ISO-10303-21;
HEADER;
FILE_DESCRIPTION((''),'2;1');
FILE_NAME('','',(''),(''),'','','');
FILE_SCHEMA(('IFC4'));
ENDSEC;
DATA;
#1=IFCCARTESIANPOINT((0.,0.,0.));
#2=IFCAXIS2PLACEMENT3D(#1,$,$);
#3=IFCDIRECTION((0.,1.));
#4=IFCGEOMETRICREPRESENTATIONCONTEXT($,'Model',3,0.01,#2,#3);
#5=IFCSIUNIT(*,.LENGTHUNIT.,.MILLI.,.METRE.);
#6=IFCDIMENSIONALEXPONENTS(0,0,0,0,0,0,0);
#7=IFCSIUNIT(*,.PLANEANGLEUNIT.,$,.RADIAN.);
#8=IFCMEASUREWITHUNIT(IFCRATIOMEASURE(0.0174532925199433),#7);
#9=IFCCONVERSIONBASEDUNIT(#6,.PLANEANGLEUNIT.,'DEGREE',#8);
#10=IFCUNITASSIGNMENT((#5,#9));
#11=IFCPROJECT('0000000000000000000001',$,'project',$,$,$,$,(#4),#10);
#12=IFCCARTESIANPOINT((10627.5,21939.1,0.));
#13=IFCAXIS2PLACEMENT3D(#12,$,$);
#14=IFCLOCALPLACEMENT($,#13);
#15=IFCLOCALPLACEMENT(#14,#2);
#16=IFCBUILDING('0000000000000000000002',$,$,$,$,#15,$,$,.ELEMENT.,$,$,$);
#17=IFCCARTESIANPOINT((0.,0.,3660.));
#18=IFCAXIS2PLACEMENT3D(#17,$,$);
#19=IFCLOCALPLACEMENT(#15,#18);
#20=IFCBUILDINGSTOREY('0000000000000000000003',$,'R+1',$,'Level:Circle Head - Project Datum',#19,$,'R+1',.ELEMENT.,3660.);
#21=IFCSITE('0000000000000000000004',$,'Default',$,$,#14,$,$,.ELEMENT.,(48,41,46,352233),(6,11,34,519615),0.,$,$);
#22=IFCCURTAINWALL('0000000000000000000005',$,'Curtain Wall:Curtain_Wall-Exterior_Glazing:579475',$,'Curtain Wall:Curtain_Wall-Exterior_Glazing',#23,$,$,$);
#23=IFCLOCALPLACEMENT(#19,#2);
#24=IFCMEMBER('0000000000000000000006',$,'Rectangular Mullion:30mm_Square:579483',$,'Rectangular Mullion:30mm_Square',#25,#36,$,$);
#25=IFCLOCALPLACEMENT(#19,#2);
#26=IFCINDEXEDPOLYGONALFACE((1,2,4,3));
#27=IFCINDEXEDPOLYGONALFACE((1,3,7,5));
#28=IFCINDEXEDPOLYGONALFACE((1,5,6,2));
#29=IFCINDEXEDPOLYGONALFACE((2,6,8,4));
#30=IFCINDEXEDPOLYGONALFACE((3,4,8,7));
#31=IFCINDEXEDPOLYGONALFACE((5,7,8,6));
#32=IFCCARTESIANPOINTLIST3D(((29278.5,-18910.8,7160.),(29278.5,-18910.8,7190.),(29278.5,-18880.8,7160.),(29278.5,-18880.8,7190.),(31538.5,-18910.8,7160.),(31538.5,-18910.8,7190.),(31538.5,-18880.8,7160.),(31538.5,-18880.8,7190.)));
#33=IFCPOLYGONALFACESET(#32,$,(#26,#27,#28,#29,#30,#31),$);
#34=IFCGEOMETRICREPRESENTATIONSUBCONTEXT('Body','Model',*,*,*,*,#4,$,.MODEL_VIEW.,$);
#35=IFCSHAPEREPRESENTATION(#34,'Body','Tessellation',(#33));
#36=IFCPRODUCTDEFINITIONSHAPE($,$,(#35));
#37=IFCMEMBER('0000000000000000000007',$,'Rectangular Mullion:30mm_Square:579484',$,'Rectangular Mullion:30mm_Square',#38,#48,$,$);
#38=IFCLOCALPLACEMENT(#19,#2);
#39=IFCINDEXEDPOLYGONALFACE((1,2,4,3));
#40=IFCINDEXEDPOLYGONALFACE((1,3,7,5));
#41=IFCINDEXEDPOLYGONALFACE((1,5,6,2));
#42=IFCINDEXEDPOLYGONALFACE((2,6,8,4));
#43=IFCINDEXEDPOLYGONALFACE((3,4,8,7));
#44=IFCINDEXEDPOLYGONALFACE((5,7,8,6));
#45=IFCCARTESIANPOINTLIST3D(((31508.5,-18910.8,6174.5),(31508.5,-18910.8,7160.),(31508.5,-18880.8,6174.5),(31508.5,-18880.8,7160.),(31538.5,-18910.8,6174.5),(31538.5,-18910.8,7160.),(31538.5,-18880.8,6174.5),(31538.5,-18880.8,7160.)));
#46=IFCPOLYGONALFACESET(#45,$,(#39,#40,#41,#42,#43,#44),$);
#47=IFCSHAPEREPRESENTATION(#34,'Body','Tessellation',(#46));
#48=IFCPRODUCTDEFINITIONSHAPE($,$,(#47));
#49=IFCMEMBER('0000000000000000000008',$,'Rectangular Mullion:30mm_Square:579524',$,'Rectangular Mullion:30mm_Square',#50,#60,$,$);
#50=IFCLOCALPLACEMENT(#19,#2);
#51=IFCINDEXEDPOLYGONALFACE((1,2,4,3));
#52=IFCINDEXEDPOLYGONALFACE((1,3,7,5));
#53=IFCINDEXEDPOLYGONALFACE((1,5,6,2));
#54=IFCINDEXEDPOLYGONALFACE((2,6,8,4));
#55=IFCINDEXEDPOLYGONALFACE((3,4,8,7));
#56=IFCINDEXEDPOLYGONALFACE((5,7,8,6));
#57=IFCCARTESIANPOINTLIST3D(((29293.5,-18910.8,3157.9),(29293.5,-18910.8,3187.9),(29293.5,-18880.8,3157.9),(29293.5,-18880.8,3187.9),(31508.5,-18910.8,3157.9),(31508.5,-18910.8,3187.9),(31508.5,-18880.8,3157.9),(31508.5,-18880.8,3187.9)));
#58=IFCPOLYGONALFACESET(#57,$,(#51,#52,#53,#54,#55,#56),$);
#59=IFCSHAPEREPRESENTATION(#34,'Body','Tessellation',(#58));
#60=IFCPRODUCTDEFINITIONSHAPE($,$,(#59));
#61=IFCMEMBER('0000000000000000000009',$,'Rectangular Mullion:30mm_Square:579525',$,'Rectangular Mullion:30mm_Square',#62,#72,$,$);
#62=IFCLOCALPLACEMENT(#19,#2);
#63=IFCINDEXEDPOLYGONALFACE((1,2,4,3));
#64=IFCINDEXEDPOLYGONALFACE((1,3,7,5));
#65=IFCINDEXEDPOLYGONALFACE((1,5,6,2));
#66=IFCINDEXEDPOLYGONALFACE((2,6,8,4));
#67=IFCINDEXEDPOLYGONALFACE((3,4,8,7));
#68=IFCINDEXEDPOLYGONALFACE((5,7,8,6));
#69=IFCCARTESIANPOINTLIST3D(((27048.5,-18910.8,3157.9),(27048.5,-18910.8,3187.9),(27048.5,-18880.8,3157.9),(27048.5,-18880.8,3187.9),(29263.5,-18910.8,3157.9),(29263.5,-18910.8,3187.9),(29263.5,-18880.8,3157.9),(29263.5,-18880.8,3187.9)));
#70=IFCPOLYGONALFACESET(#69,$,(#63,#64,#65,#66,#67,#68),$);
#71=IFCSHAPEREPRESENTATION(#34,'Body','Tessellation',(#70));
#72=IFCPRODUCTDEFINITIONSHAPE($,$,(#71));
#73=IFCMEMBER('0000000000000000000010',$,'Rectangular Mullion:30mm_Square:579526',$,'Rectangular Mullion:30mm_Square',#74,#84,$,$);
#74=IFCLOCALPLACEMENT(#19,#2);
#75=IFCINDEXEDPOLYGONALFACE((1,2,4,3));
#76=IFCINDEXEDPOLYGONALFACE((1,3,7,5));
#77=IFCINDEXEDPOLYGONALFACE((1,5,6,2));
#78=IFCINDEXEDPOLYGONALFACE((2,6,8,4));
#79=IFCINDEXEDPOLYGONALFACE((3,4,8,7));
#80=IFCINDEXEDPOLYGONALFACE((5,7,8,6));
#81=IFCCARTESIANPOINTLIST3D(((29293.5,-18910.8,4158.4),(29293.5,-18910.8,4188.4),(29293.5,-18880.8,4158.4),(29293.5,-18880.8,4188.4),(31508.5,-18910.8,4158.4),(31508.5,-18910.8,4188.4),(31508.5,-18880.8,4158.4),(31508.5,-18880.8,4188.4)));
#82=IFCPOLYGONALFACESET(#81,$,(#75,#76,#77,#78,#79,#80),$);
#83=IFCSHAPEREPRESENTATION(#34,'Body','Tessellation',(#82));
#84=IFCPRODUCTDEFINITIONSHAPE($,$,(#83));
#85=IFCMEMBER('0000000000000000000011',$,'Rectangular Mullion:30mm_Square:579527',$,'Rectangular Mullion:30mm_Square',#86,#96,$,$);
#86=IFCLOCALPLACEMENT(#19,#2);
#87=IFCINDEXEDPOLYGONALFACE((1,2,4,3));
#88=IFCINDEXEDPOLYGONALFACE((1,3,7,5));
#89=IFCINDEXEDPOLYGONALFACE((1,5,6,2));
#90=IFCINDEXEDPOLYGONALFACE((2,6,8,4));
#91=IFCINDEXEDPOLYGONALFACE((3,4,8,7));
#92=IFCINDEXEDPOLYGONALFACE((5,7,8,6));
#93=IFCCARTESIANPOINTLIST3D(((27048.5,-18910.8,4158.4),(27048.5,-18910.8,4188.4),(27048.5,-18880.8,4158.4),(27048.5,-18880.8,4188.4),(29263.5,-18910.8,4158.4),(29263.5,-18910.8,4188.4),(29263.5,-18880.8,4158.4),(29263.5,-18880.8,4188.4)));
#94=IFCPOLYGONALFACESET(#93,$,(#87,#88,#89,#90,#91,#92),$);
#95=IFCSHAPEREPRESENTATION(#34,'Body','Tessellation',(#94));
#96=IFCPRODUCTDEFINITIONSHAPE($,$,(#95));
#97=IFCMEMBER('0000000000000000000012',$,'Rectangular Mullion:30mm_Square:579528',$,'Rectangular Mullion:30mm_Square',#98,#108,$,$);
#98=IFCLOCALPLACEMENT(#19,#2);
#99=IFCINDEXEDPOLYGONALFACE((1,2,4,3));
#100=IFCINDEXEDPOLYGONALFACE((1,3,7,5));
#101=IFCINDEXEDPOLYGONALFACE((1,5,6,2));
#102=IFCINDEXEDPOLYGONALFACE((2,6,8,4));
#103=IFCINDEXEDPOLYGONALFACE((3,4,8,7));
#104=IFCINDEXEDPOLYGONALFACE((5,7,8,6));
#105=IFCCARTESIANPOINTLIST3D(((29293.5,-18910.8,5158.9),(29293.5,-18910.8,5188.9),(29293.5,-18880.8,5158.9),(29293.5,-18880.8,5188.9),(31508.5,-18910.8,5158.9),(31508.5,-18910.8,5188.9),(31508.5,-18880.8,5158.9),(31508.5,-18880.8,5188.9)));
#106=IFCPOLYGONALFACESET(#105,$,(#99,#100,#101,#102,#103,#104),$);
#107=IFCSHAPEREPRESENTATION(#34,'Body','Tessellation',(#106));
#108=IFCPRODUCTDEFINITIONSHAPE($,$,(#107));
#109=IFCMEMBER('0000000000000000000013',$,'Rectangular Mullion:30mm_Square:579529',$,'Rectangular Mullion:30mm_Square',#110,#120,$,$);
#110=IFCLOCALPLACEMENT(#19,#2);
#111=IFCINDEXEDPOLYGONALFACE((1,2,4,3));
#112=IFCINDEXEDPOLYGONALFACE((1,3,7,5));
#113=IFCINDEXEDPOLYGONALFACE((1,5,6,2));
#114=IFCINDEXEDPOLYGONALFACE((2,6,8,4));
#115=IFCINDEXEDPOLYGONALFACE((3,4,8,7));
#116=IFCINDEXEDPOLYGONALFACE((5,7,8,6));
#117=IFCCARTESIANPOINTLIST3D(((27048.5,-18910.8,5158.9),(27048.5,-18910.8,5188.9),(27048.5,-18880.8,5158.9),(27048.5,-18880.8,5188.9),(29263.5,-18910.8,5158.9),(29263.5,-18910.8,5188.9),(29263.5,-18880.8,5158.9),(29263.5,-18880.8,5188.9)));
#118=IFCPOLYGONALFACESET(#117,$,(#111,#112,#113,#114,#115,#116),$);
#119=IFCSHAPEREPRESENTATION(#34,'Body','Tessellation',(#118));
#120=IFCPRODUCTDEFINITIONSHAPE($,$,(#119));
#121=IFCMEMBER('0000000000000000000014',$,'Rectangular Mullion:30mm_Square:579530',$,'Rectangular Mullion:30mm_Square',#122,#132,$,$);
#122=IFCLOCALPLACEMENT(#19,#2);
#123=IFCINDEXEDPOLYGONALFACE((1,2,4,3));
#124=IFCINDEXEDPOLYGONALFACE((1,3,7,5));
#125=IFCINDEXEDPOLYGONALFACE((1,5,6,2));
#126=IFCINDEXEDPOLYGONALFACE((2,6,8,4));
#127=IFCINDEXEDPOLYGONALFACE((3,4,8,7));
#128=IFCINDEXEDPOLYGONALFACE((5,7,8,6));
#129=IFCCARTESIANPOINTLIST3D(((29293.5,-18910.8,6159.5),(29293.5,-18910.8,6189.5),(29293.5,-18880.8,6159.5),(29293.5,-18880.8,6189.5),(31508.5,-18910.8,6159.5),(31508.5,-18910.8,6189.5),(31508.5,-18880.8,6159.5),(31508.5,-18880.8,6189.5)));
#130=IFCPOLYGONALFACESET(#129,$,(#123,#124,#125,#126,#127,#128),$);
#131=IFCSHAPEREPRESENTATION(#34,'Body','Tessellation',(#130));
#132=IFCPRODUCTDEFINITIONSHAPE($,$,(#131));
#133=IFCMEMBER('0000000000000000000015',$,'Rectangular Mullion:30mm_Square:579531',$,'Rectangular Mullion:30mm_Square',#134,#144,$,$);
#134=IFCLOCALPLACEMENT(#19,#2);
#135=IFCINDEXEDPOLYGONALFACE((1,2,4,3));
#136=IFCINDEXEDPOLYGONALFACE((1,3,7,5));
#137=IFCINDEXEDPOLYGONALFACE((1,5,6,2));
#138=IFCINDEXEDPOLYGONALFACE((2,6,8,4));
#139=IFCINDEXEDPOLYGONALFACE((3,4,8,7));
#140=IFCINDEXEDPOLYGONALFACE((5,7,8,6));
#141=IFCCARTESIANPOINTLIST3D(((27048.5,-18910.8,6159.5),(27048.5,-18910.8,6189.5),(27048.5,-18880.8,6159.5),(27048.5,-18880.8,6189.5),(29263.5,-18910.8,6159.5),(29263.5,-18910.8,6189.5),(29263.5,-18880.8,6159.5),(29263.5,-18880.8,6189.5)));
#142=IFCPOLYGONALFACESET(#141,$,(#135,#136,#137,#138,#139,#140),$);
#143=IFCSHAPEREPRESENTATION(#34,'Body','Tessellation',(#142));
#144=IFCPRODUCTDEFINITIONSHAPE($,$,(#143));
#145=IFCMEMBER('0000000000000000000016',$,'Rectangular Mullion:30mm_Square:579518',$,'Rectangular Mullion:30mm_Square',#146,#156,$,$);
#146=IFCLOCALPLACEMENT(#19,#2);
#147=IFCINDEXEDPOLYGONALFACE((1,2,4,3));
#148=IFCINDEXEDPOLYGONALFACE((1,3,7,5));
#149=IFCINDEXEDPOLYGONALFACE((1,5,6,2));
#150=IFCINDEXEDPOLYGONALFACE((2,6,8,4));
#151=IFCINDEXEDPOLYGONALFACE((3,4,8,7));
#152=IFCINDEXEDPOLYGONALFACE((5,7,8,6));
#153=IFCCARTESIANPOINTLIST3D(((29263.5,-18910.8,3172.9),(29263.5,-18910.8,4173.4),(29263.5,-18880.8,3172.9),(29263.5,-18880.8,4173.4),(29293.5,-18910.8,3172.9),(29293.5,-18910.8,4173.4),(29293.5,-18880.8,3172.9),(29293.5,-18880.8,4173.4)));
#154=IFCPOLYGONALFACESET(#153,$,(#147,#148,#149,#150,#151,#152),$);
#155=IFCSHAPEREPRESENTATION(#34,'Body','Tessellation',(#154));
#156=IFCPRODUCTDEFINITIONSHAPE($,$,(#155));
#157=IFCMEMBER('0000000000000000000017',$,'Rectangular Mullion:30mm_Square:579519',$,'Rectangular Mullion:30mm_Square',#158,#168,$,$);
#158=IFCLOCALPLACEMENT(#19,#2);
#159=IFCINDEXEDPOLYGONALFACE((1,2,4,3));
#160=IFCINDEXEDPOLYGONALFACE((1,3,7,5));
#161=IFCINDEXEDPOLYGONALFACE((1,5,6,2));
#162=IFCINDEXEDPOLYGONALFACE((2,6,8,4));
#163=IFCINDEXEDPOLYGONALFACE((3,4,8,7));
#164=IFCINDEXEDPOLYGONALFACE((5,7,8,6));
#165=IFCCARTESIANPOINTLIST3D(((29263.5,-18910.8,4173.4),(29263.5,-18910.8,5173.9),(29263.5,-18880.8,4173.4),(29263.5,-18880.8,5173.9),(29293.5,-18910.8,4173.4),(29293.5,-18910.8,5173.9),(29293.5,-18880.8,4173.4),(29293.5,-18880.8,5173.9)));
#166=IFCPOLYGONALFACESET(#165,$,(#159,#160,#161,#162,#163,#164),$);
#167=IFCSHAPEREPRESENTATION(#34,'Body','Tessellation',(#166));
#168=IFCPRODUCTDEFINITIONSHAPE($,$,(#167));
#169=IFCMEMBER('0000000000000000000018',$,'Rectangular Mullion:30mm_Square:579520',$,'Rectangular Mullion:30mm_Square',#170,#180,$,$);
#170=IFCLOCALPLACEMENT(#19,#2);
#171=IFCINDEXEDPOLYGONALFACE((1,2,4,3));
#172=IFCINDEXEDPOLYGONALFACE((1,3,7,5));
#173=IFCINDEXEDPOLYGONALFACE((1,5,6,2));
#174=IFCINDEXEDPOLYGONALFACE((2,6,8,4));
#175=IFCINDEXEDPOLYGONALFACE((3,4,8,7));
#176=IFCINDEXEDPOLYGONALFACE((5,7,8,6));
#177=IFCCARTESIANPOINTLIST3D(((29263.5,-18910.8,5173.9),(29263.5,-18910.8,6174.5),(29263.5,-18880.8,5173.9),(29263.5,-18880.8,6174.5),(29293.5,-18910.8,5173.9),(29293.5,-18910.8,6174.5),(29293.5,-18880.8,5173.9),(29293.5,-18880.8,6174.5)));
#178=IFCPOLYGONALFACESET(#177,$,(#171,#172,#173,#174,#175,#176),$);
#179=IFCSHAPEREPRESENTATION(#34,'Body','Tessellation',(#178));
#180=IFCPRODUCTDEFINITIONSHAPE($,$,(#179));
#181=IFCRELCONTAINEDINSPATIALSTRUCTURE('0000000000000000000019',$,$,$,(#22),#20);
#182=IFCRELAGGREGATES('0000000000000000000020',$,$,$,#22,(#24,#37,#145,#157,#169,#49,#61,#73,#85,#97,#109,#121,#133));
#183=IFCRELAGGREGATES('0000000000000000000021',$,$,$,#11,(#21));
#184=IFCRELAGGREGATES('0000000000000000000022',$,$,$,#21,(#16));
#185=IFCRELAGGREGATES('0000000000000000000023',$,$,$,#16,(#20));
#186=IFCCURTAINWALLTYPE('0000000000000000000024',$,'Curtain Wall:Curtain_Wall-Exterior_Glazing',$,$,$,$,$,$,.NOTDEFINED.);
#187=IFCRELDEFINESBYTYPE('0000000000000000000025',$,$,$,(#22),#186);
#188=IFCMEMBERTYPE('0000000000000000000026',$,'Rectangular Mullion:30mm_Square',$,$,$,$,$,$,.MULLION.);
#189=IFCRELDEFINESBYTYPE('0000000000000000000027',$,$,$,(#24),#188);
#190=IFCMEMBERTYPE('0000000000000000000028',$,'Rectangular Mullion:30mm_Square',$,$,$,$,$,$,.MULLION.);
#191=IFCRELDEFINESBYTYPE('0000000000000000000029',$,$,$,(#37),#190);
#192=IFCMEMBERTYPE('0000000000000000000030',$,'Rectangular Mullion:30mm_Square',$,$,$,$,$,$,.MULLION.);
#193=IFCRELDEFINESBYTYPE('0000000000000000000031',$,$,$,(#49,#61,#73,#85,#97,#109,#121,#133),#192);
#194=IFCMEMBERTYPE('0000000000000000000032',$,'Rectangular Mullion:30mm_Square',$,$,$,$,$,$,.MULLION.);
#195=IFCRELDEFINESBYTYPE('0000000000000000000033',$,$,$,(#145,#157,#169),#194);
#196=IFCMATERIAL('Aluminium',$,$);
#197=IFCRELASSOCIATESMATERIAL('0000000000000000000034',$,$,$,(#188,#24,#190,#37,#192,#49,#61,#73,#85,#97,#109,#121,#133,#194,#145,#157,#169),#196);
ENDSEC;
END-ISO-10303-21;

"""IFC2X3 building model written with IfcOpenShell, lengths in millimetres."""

from ifc_helpers import new_model, entity, si_unit, converted_unit, direction, frame, origin, origin_2d_with_axis, place, context, subcontext, project, spatial, rectangle, extrude, source, transform, mapped, material, type_object, type_shapes, element, aggregate, save


model = new_model("IFC2X3")

# Units and contexts
model_context = context("Model", 3, precision=0.01, world=origin(), true_north=direction((0.0, 1.0)))
body_context = subcontext(model_context, "Body", "Model", "MODEL_VIEW")
ifc_project = project(units=[si_unit("LENGTHUNIT", "METRE", prefix="MILLI"), converted_unit("PLANEANGLEUNIT", "DEGREE", entity("IfcRatioMeasure", 0.0174532925199433), si_unit("PLANEANGLEUNIT", "RADIAN"), dimensions=[0, 0, 0, 0, 0, 0, 0])], contexts=[model_context])

# Site, building, storey
site_placement = place(None, frame((10627.5, 21939.1, 0.0)))
site = spatial("IfcSite", under=ifc_project, at=site_placement, Name="Default", CompositionType="ELEMENT", RefLatitude=(48, 41, 46, 352233), RefLongitude=(6, 11, 34, 519615), RefElevation=0.0)
building_placement = place(site_placement, origin())
building = spatial("IfcBuilding", under=site, at=building_placement, CompositionType="ELEMENT")
storey_placement = place(building_placement, frame((0.0, 0.0, 3660.0)))
storey = spatial("IfcBuildingStorey", under=building, at=storey_placement, Name="R+1", ObjectType="Level:Circle Head - Project Datum", LongName="R+1", CompositionType="ELEMENT", Elevation=3660.0)

# Curtain wall, members
curtain_wall_type = type_object("IfcCurtainWallType", Name="Curtain Wall:Curtain_Wall-Exterior_Glazing", PredefinedType="NOTDEFINED")
curtain_wall_placement = place(storey_placement, frame((0.0, 0.0, -3660.0)))
curtain_wall = element("IfcCurtainWall", 1, at=curtain_wall_placement, inside=storey, type_object=curtain_wall_type, Name="Curtain Wall:Curtain_Wall-Exterior_Glazing:579475", ObjectType="Curtain Wall:Curtain_Wall-Exterior_Glazing")
ifc_material_1 = material(Name="Aluminium")
member_type_1 = type_object("IfcMemberType", Name="Rectangular Mullion:30mm_Square", PredefinedType="MULLION", material=ifc_material_1)
shared_shape_1 = source(origin(), body_context, "Body", "SweptSolid", [
    extrude(rectangle(XDim=30.0, YDim=30.0, at=origin_2d_with_axis()), frame((-15.0, 0.0, -2260.0), z_axis=(0.0, 0.0, 1.0), x_axis=(0.0, -1.0, 0.0)), (0.0, 0.0, 1.0), 2260.0),
])
type_shapes(member_type_1, [shared_shape_1])
member_1_placement = place(storey_placement, frame((29278.5, -18895.8, 7190.0), z_axis=(-1.0, 0.0, 0.0), x_axis=(0.0, 0.0, 1.0)))
member_1 = element("IfcMember", 2, at=member_1_placement, type_object=member_type_1, material=ifc_material_1, Name="Rectangular Mullion:30mm_Square:579483", ObjectType="Rectangular Mullion:30mm_Square", context=body_context, shape_type="MappedRepresentation", body=[
    mapped(shared_shape_1, transform((0.0, 0.0, 0.0), scale=1.0)),
])
member_type_2 = type_object("IfcMemberType", Name="Rectangular Mullion:30mm_Square", PredefinedType="MULLION", material=ifc_material_1)
shared_shape_2 = source(origin(), body_context, "Body", "SweptSolid", [
    extrude(rectangle(XDim=30.0, YDim=30.0, at=origin_2d_with_axis()), frame((-15.0, 0.0, -985.5), z_axis=(0.0, 0.0, 1.0), x_axis=(0.0, -1.0, 0.0)), (0.0, 0.0, 1.0), 985.5),
])
type_shapes(member_type_2, [shared_shape_2])
member_2_placement = place(storey_placement, frame((31538.5, -18895.8, 7160.0)))
member_2 = element("IfcMember", 3, at=member_2_placement, type_object=member_type_2, material=ifc_material_1, Name="Rectangular Mullion:30mm_Square:579484", ObjectType="Rectangular Mullion:30mm_Square", context=body_context, shape_type="MappedRepresentation", body=[
    mapped(shared_shape_2, transform((0.0, 0.0, 0.0), scale=1.0)),
])
member_type_3 = type_object("IfcMemberType", Name="Rectangular Mullion:30mm_Square", PredefinedType="MULLION", material=ifc_material_1)
shared_shape_3 = source(origin(), body_context, "Body", "SweptSolid", [
    extrude(rectangle(XDim=30.0, YDim=30.0, at=origin_2d_with_axis()), frame((0.0, 0.0, -2215.0), z_axis=(0.0, 0.0, 1.0), x_axis=(0.0, -1.0, 0.0)), (0.0, 0.0, 1.0), 2215.0),
])
type_shapes(member_type_3, [shared_shape_3])
member_3_placement = place(storey_placement, frame((29293.5, -18895.8, 3172.9), z_axis=(-1.0, 0.0, 0.0), x_axis=(0.0, 0.0, 1.0)))
member_3 = element("IfcMember", 4, at=member_3_placement, type_object=member_type_3, material=ifc_material_1, Name="Rectangular Mullion:30mm_Square:579524", ObjectType="Rectangular Mullion:30mm_Square", context=body_context, shape_type="MappedRepresentation", body=[
    mapped(shared_shape_3, transform((0.0, 0.0, 0.0), scale=1.0)),
])
member_4_placement = place(storey_placement, frame((27048.5, -18895.8, 3172.9), z_axis=(-1.0, 0.0, 0.0), x_axis=(0.0, 0.0, 1.0)))
member_4 = element("IfcMember", 5, at=member_4_placement, type_object=member_type_3, material=ifc_material_1, Name="Rectangular Mullion:30mm_Square:579525", ObjectType="Rectangular Mullion:30mm_Square", context=body_context, shape_type="MappedRepresentation", body=[
    mapped(shared_shape_3, transform((0.0, 0.0, 0.0), scale=1.0)),
])
member_5_placement = place(storey_placement, frame((29293.5, -18895.8, 4173.4), z_axis=(-1.0, 0.0, 0.0), x_axis=(0.0, 0.0, 1.0)))
member_5 = element("IfcMember", 6, at=member_5_placement, type_object=member_type_3, material=ifc_material_1, Name="Rectangular Mullion:30mm_Square:579526", ObjectType="Rectangular Mullion:30mm_Square", context=body_context, shape_type="MappedRepresentation", body=[
    mapped(shared_shape_3, transform((0.0, 0.0, 0.0), scale=1.0)),
])
member_6_placement = place(storey_placement, frame((27048.5, -18895.8, 4173.4), z_axis=(-1.0, 0.0, 0.0), x_axis=(0.0, 0.0, 1.0)))
member_6 = element("IfcMember", 7, at=member_6_placement, type_object=member_type_3, material=ifc_material_1, Name="Rectangular Mullion:30mm_Square:579527", ObjectType="Rectangular Mullion:30mm_Square", context=body_context, shape_type="MappedRepresentation", body=[
    mapped(shared_shape_3, transform((0.0, 0.0, 0.0), scale=1.0)),
])
member_7_placement = place(storey_placement, frame((29293.5, -18895.8, 5173.9), z_axis=(-1.0, 0.0, 0.0), x_axis=(0.0, 0.0, 1.0)))
member_7 = element("IfcMember", 8, at=member_7_placement, type_object=member_type_3, material=ifc_material_1, Name="Rectangular Mullion:30mm_Square:579528", ObjectType="Rectangular Mullion:30mm_Square", context=body_context, shape_type="MappedRepresentation", body=[
    mapped(shared_shape_3, transform((0.0, 0.0, 0.0), scale=1.0)),
])
member_8_placement = place(storey_placement, frame((27048.5, -18895.8, 5173.9), z_axis=(-1.0, 0.0, 0.0), x_axis=(0.0, 0.0, 1.0)))
member_8 = element("IfcMember", 9, at=member_8_placement, type_object=member_type_3, material=ifc_material_1, Name="Rectangular Mullion:30mm_Square:579529", ObjectType="Rectangular Mullion:30mm_Square", context=body_context, shape_type="MappedRepresentation", body=[
    mapped(shared_shape_3, transform((0.0, 0.0, 0.0), scale=1.0)),
])
member_9_placement = place(storey_placement, frame((29293.5, -18895.8, 6174.5), z_axis=(-1.0, 0.0, 0.0), x_axis=(0.0, 0.0, 1.0)))
member_9 = element("IfcMember", 10, at=member_9_placement, type_object=member_type_3, material=ifc_material_1, Name="Rectangular Mullion:30mm_Square:579530", ObjectType="Rectangular Mullion:30mm_Square", context=body_context, shape_type="MappedRepresentation", body=[
    mapped(shared_shape_3, transform((0.0, 0.0, 0.0), scale=1.0)),
])
member_10_placement = place(storey_placement, frame((27048.5, -18895.8, 6174.5), z_axis=(-1.0, 0.0, 0.0), x_axis=(0.0, 0.0, 1.0)))
member_10 = element("IfcMember", 11, at=member_10_placement, type_object=member_type_3, material=ifc_material_1, Name="Rectangular Mullion:30mm_Square:579531", ObjectType="Rectangular Mullion:30mm_Square", context=body_context, shape_type="MappedRepresentation", body=[
    mapped(shared_shape_3, transform((0.0, 0.0, 0.0), scale=1.0)),
])
member_type_4 = type_object("IfcMemberType", Name="Rectangular Mullion:30mm_Square", PredefinedType="MULLION", material=ifc_material_1)
shared_shape_4 = source(origin(), body_context, "Body", "SweptSolid", [
    extrude(rectangle(XDim=30.0, YDim=30.0, at=origin_2d_with_axis()), frame((0.0, 0.0, -1000.5), z_axis=(0.0, 0.0, 1.0), x_axis=(0.0, -1.0, 0.0)), (0.0, 0.0, 1.0), 1000.5),
])
type_shapes(member_type_4, [shared_shape_4])
member_11_placement = place(storey_placement, frame((29278.5, -18895.8, 3172.9), z_axis=(0.0, 0.0, -1.0), x_axis=(-1.0, 0.0, 0.0)))
member_11 = element("IfcMember", 12, at=member_11_placement, type_object=member_type_4, material=ifc_material_1, Name="Rectangular Mullion:30mm_Square:579518", ObjectType="Rectangular Mullion:30mm_Square", context=body_context, shape_type="MappedRepresentation", body=[
    mapped(shared_shape_4, transform((0.0, 0.0, 0.0), scale=1.0)),
])
member_12_placement = place(storey_placement, frame((29278.5, -18895.8, 4173.4), z_axis=(0.0, 0.0, -1.0), x_axis=(-1.0, 0.0, 0.0)))
member_12 = element("IfcMember", 13, at=member_12_placement, type_object=member_type_4, material=ifc_material_1, Name="Rectangular Mullion:30mm_Square:579519", ObjectType="Rectangular Mullion:30mm_Square", context=body_context, shape_type="MappedRepresentation", body=[
    mapped(shared_shape_4, transform((0.0, 0.0, 0.0), scale=1.0)),
])
member_13_placement = place(storey_placement, frame((29278.5, -18895.8, 5173.9), z_axis=(0.0, 0.0, -1.0), x_axis=(-1.0, 0.0, 0.0)))
member_13 = element("IfcMember", 14, at=member_13_placement, type_object=member_type_4, material=ifc_material_1, Name="Rectangular Mullion:30mm_Square:579520", ObjectType="Rectangular Mullion:30mm_Square", context=body_context, shape_type="MappedRepresentation", body=[
    mapped(shared_shape_4, transform((0.0, 0.0, 0.0), scale=1.0)),
])
aggregate(curtain_wall, [member_1, member_2, member_11, member_12, member_13, member_3, member_4, member_5, member_6, member_7, member_8, member_9, member_10])

save(model, "model.ifc")
